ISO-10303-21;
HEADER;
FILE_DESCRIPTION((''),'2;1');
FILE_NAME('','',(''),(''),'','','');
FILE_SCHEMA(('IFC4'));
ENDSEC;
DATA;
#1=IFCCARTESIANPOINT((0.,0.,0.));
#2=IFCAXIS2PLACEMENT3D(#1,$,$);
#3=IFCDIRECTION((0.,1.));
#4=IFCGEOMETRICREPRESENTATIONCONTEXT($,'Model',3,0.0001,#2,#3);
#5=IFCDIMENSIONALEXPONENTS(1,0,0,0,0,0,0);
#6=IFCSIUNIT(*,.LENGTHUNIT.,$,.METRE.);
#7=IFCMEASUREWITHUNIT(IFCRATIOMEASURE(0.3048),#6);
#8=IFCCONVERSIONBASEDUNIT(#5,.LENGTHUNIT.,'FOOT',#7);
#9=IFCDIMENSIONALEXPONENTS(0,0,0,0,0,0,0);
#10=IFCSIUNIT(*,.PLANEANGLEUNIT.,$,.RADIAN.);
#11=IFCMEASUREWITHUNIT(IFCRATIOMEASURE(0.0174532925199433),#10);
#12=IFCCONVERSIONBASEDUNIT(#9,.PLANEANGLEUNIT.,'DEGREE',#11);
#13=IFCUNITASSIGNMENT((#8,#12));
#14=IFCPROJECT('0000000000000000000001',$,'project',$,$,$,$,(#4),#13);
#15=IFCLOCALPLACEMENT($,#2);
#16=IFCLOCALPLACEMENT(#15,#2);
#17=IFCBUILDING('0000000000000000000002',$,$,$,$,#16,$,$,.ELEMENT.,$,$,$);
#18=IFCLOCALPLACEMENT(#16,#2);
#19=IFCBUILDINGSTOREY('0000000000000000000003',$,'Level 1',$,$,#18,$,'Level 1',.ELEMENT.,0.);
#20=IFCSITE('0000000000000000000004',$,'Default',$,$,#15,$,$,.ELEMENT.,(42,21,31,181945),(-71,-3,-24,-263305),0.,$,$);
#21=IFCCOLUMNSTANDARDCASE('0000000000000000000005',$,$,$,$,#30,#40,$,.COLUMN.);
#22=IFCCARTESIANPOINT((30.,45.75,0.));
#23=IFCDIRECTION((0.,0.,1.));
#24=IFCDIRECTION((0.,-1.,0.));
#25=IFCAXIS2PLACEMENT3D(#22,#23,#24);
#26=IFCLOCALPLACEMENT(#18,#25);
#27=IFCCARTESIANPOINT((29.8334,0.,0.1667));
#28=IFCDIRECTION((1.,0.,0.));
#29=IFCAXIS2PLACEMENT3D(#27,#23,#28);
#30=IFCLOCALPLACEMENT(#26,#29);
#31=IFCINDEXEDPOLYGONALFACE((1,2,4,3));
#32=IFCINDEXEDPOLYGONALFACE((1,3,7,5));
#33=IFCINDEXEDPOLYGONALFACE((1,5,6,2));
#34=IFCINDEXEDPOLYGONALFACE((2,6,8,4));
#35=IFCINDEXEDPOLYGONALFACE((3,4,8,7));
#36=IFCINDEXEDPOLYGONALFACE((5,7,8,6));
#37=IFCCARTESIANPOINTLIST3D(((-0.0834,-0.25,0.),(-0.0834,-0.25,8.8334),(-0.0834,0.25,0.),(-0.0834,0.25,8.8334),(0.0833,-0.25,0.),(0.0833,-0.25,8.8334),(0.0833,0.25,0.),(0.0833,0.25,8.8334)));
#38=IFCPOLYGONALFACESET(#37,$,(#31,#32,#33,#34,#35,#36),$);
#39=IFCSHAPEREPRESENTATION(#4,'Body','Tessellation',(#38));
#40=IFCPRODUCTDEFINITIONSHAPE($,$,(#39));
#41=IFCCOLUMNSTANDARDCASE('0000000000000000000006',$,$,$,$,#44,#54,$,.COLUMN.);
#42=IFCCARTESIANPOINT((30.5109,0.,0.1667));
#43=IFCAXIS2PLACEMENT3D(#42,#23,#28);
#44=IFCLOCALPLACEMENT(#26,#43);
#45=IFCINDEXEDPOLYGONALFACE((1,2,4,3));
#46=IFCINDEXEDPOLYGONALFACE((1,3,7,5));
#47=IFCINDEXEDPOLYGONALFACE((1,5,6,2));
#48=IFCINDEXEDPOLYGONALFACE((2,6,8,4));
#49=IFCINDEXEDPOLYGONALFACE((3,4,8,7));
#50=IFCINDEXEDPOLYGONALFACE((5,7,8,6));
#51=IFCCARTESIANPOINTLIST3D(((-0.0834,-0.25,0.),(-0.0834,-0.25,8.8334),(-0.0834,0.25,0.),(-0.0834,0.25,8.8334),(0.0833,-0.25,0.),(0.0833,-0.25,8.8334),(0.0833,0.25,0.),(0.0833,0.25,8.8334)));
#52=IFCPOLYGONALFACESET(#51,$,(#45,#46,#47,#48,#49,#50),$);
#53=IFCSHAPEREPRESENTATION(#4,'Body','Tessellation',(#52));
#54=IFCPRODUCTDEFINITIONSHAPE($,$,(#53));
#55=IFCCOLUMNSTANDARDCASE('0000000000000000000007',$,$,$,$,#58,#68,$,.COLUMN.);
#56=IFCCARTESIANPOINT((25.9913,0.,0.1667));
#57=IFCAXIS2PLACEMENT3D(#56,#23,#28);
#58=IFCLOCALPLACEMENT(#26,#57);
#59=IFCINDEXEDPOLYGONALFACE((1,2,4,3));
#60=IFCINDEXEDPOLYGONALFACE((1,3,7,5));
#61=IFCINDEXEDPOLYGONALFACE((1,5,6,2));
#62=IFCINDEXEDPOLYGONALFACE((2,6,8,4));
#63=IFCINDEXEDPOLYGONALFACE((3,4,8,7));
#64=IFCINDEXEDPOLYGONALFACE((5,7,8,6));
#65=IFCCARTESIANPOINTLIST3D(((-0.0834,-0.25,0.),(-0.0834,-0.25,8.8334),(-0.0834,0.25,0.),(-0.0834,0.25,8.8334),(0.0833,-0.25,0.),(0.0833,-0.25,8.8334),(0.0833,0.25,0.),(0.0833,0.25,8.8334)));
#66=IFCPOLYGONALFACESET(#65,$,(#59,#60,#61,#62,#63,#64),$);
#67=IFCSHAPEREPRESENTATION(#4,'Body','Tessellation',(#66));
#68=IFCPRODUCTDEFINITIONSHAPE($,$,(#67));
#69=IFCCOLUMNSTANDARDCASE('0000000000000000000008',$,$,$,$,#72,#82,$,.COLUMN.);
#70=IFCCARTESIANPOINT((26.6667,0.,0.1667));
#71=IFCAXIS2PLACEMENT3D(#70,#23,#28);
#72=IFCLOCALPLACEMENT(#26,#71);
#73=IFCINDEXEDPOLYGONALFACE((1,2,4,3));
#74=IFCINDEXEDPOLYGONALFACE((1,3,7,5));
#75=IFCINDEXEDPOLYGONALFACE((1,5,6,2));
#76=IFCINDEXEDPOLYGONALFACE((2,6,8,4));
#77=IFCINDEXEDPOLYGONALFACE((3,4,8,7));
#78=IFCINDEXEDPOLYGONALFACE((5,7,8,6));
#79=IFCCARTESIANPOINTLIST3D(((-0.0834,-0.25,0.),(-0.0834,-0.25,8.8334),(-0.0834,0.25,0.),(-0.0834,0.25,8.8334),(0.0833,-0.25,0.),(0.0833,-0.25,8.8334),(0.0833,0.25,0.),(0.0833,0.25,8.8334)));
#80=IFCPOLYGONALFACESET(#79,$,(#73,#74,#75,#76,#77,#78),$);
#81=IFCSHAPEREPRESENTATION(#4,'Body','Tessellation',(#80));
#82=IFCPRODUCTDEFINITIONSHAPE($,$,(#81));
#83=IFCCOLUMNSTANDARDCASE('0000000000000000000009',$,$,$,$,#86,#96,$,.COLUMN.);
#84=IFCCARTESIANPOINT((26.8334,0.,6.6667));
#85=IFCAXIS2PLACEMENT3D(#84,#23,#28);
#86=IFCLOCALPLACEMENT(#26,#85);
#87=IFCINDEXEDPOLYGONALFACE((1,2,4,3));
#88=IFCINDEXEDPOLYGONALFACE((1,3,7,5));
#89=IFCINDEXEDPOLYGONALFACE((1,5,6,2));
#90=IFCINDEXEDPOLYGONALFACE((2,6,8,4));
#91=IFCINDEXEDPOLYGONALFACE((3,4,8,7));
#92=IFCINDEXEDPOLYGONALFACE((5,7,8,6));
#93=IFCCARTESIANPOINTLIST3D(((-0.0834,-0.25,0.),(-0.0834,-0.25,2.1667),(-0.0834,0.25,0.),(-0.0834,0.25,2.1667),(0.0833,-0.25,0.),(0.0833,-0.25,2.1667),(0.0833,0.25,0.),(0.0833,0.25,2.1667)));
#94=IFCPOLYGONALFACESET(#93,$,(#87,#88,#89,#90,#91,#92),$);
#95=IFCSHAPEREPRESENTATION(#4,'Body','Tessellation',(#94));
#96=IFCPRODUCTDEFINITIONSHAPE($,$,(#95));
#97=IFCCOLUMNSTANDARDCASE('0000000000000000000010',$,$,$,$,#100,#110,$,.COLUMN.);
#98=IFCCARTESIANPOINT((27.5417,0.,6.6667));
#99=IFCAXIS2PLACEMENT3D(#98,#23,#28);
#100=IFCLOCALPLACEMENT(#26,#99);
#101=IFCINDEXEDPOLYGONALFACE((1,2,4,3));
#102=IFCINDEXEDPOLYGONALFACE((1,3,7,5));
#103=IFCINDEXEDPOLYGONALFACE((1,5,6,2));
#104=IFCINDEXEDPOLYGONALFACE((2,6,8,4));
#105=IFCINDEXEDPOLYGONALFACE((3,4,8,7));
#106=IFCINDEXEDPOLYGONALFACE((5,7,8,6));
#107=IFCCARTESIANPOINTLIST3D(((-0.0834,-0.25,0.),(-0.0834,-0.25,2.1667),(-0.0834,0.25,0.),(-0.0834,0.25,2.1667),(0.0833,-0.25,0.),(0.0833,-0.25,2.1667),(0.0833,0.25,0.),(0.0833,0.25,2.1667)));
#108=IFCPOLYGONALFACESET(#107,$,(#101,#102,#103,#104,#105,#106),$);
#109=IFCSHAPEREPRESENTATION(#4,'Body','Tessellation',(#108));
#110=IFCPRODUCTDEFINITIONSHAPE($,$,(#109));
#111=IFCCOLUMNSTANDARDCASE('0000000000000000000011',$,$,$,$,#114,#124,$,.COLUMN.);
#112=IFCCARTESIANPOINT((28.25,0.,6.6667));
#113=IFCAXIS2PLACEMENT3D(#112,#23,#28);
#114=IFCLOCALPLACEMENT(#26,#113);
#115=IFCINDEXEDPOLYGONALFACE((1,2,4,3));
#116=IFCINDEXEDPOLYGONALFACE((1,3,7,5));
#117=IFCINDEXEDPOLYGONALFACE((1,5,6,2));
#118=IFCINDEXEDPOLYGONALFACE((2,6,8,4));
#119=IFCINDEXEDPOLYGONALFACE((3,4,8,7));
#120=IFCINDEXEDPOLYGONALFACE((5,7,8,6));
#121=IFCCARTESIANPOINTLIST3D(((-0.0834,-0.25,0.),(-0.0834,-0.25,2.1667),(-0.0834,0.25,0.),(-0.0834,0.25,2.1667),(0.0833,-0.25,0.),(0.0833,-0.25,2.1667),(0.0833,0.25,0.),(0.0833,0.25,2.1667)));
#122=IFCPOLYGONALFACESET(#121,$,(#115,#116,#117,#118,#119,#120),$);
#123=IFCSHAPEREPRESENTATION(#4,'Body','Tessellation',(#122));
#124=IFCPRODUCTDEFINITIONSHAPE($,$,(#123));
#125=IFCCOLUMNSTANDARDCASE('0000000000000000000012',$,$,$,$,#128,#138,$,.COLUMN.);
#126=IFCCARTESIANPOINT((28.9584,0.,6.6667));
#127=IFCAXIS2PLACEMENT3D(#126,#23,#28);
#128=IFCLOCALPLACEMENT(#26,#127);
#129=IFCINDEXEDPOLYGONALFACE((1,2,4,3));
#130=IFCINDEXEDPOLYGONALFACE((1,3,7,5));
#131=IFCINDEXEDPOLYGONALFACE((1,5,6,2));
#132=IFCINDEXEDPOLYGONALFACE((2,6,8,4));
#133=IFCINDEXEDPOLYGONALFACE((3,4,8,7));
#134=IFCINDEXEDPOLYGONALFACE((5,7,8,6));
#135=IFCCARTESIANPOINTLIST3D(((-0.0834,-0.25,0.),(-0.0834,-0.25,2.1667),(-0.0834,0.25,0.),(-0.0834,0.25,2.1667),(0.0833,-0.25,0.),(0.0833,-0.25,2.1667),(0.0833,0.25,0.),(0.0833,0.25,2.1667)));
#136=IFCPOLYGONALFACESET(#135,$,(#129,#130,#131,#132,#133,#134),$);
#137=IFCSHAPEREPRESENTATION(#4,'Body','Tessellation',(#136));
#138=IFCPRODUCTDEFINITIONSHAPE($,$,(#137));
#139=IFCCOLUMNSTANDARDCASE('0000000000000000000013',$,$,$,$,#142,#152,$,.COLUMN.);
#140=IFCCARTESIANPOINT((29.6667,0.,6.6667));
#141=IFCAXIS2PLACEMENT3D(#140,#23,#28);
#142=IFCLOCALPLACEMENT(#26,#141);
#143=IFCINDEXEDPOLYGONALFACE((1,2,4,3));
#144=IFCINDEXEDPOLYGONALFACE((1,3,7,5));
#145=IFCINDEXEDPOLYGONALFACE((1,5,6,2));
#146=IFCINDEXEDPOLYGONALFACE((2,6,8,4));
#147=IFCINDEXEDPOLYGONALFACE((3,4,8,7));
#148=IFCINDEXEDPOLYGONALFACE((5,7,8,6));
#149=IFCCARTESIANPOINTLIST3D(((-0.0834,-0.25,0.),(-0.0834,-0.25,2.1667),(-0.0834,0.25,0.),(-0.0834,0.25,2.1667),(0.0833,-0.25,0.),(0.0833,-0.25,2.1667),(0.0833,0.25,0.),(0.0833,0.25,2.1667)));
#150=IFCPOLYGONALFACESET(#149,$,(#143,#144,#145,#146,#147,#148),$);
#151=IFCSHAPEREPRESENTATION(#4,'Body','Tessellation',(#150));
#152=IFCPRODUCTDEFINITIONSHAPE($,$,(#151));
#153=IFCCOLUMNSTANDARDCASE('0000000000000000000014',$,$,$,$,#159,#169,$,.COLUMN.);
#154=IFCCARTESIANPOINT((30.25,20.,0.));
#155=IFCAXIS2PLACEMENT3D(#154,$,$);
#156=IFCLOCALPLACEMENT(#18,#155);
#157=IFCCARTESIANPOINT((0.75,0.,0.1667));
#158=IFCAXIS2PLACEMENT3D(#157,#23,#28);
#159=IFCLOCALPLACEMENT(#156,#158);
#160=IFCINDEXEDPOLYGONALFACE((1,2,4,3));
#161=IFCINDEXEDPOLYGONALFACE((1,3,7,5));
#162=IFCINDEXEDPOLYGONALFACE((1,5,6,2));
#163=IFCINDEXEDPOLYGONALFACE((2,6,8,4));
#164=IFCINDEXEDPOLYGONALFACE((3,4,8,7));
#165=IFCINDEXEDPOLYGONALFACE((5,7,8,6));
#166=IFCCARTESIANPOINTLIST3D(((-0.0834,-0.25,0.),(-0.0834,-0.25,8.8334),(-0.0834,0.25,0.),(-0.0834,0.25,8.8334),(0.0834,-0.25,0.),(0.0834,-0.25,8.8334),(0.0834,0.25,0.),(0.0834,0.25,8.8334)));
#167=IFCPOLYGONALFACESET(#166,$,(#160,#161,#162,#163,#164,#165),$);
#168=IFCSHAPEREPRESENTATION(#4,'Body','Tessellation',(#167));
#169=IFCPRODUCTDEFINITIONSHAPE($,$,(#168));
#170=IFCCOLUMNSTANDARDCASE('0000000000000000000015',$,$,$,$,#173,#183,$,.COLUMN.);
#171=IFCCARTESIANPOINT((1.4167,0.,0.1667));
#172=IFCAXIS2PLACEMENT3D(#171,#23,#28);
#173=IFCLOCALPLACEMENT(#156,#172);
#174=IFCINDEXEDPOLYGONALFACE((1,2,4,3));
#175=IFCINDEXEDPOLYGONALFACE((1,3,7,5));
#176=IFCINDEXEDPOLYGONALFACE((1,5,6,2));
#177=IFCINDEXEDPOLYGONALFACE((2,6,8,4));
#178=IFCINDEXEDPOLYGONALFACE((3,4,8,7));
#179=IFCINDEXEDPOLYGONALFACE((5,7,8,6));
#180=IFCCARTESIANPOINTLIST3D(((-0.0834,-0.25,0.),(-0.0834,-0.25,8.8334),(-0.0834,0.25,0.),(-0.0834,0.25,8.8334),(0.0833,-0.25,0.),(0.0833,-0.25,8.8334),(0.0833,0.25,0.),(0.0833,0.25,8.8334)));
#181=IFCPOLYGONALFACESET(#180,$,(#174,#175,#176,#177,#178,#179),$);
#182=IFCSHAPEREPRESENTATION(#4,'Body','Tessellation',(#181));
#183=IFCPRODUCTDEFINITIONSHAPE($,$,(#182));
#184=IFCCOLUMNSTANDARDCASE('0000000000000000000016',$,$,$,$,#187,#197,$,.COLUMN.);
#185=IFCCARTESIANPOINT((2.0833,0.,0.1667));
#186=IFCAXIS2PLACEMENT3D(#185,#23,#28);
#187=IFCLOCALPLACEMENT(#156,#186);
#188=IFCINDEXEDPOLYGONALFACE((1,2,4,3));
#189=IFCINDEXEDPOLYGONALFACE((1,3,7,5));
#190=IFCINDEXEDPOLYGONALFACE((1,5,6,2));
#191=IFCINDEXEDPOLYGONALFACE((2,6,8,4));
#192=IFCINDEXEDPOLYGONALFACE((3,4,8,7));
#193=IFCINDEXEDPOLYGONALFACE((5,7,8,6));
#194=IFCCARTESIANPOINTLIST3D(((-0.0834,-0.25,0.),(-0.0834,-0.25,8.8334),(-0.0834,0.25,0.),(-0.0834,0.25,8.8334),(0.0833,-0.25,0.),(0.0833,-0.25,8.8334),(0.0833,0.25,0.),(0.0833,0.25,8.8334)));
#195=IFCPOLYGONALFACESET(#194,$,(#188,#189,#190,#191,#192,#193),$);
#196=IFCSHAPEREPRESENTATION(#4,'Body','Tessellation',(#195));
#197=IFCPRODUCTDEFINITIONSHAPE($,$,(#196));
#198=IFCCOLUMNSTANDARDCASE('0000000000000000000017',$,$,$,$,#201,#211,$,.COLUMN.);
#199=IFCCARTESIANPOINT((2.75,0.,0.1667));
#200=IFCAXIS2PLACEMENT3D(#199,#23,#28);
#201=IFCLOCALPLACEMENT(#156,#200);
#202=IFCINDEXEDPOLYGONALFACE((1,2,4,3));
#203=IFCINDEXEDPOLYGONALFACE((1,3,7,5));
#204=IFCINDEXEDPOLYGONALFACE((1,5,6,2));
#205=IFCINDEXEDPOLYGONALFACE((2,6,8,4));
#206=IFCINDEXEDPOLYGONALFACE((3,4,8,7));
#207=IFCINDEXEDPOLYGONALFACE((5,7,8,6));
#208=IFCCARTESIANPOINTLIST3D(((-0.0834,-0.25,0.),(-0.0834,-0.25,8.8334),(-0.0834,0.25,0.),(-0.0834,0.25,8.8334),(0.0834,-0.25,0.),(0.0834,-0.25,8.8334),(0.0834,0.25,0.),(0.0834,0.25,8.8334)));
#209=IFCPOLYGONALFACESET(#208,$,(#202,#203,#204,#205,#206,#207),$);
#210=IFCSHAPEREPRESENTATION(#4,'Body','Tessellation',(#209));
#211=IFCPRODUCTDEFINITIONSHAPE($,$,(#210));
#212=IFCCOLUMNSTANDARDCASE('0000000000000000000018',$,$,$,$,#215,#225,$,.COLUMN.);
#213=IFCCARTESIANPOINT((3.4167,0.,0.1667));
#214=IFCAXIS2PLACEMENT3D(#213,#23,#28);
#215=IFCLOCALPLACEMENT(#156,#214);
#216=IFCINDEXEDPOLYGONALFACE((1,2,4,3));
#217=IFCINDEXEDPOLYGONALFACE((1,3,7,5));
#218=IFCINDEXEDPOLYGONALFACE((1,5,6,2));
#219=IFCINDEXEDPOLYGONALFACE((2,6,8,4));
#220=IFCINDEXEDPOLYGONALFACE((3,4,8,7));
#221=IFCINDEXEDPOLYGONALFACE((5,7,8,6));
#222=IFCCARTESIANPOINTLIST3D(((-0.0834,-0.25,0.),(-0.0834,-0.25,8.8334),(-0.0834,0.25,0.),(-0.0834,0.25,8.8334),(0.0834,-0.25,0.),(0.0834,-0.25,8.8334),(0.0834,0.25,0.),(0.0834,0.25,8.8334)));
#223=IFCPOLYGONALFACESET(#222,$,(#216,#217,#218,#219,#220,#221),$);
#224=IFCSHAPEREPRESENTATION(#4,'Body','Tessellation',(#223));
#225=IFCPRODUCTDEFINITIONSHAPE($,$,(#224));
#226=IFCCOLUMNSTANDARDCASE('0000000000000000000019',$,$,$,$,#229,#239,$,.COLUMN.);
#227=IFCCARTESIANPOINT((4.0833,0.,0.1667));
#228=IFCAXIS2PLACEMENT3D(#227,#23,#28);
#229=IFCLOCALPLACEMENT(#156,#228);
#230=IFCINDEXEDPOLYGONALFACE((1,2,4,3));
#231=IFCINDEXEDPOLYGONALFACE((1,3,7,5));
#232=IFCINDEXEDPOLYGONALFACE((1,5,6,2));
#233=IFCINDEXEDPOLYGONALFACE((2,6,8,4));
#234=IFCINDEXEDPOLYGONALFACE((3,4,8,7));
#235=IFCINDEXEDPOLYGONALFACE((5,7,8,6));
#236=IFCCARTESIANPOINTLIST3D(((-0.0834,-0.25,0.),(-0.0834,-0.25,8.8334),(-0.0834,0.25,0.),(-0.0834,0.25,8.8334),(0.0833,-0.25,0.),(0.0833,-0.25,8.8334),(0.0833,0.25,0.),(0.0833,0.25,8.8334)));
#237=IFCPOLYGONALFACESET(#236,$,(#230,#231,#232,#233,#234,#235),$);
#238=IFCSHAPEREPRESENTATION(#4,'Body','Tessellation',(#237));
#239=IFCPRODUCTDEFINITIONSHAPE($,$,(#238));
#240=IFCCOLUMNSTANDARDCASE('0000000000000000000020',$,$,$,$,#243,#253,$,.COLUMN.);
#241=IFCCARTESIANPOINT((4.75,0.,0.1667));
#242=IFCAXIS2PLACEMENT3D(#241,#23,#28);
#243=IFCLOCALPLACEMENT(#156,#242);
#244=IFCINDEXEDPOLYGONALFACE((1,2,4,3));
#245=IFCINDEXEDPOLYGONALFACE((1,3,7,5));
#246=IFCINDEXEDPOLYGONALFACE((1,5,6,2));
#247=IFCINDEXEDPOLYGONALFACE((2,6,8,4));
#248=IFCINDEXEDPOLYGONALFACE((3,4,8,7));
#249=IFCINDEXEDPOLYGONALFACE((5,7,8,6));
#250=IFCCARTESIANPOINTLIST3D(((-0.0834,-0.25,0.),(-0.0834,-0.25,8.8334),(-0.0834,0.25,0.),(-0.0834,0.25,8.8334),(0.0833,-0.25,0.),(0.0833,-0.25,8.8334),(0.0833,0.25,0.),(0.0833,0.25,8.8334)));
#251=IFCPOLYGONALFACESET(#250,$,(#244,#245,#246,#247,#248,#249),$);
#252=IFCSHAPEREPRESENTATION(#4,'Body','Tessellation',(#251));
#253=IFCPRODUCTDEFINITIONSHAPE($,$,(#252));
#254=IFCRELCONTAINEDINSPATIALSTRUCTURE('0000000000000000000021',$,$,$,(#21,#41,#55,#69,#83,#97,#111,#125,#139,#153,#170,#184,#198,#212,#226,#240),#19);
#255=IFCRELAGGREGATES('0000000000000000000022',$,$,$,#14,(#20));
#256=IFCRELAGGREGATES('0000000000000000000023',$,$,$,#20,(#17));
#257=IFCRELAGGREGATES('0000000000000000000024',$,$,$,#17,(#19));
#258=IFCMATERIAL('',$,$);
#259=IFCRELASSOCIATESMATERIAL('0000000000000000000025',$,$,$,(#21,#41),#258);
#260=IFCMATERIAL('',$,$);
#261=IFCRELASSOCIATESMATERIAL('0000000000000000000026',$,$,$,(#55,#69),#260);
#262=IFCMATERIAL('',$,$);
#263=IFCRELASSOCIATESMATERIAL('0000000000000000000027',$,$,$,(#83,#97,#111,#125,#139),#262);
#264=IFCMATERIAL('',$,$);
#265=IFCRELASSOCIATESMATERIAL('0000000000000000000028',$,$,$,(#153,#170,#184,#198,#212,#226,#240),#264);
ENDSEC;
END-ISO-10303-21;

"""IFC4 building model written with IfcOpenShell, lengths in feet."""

from ifc_helpers import new_model, entity, si_unit, converted_unit, direction, frame, origin, place, context, project, spatial, rectangle, extrude, material, element, save


model = new_model("IFC4")

# Units and contexts
model_context = context("Model", 3, precision=0.0001, world=origin(), true_north=direction((0.0, 1.0)))
ifc_project = project(units=[converted_unit("LENGTHUNIT", "FOOT", entity("IfcRatioMeasure", 0.3048), si_unit("LENGTHUNIT", "METRE"), dimensions=[1, 0, 0, 0, 0, 0, 0]), converted_unit("PLANEANGLEUNIT", "DEGREE", entity("IfcRatioMeasure", 0.0174532925199433), si_unit("PLANEANGLEUNIT", "RADIAN"), dimensions=[0, 0, 0, 0, 0, 0, 0])], contexts=[model_context])

# Site, building, storey
site_placement = place(None, origin())
site = spatial("IfcSite", under=ifc_project, at=site_placement, Name="Default", CompositionType="ELEMENT", RefLatitude=(42, 21, 31, 181945), RefLongitude=(-71, -3, -24, -263305), RefElevation=0.0)
building_placement = place(site_placement, origin())
building = spatial("IfcBuilding", under=site, at=building_placement, CompositionType="ELEMENT")
storey_placement = place(building_placement, origin())
storey = spatial("IfcBuildingStorey", under=building, at=storey_placement, Name="Level 1", LongName="Level 1", CompositionType="ELEMENT", Elevation=0.0)

# Columns
ifc_material_1 = material(Name="")
placement_1 = place(storey_placement, frame((30.0, 45.75, 0.0), z_axis=(0.0, 0.0, 1.0), x_axis=(0.0, -1.0, 0.0)))
for number, where, z_axis, x_axis in (
    (1, (29.8334, 0.0, 0.1667), (0.0, 0.0, 1.0), (1.0, 0.0, 0.0)),
    (2, (30.5109, 0.0, 0.1667), (0.0, 0.0, 1.0), (1.0, 0.0, 0.0)),
):
    element("IfcColumnStandardCase", number, at=place(placement_1, frame(where, z_axis=z_axis, x_axis=x_axis)), inside=storey, material=ifc_material_1, PredefinedType="COLUMN", context=model_context, shape_type="SweptSolid", body=[
        extrude(rectangle(XDim=0.1667, YDim=0.5), origin(), (0.0, 0.0, 1.0), 8.8334),
    ])
ifc_material_2 = material(Name="")
for number, where, z_axis, x_axis in (
    (3, (25.9913, 0.0, 0.1667), (0.0, 0.0, 1.0), (1.0, 0.0, 0.0)),
    (4, (26.6667, 0.0, 0.1667), (0.0, 0.0, 1.0), (1.0, 0.0, 0.0)),
):
    element("IfcColumnStandardCase", number, at=place(placement_1, frame(where, z_axis=z_axis, x_axis=x_axis)), inside=storey, material=ifc_material_2, PredefinedType="COLUMN", context=model_context, shape_type="SweptSolid", body=[
        extrude(rectangle(XDim=0.1667, YDim=0.5), origin(), (0.0, 0.0, 1.0), 8.8334),
    ])
ifc_material_3 = material(Name="")
for number, where, z_axis, x_axis in (
    (5, (26.8334, 0.0, 6.6667), (0.0, 0.0, 1.0), (1.0, 0.0, 0.0)),
    (6, (27.5417, 0.0, 6.6667), (0.0, 0.0, 1.0), (1.0, 0.0, 0.0)),
    (7, (28.25, 0.0, 6.6667), (0.0, 0.0, 1.0), (1.0, 0.0, 0.0)),
    (8, (28.9584, 0.0, 6.6667), (0.0, 0.0, 1.0), (1.0, 0.0, 0.0)),
    (9, (29.6667, 0.0, 6.6667), (0.0, 0.0, 1.0), (1.0, 0.0, 0.0)),
):
    element("IfcColumnStandardCase", number, at=place(placement_1, frame(where, z_axis=z_axis, x_axis=x_axis)), inside=storey, material=ifc_material_3, PredefinedType="COLUMN", context=model_context, shape_type="SweptSolid", body=[
        extrude(rectangle(XDim=0.1667, YDim=0.5), origin(), (0.0, 0.0, 1.0), 2.1667),
    ])
ifc_material_4 = material(Name="")
placement_2 = place(storey_placement, frame((30.25, 20.0, 0.0)))
for number, where, z_axis, x_axis in (
    (10, (0.75, 0.0, 0.1667), (0.0, 0.0, 1.0), (1.0, 0.0, 0.0)),
    (11, (1.4167, 0.0, 0.1667), (0.0, 0.0, 1.0), (1.0, 0.0, 0.0)),
    (12, (2.0833, 0.0, 0.1667), (0.0, 0.0, 1.0), (1.0, 0.0, 0.0)),
    (13, (2.75, 0.0, 0.1667), (0.0, 0.0, 1.0), (1.0, 0.0, 0.0)),
    (14, (3.4167, 0.0, 0.1667), (0.0, 0.0, 1.0), (1.0, 0.0, 0.0)),
    (15, (4.0833, 0.0, 0.1667), (0.0, 0.0, 1.0), (1.0, 0.0, 0.0)),
    (16, (4.75, 0.0, 0.1667), (0.0, 0.0, 1.0), (1.0, 0.0, 0.0)),
):
    element("IfcColumnStandardCase", number, at=place(placement_2, frame(where, z_axis=z_axis, x_axis=x_axis)), inside=storey, material=ifc_material_4, PredefinedType="COLUMN", context=model_context, shape_type="SweptSolid", body=[
        extrude(rectangle(XDim=0.1667, YDim=0.5), origin(), (0.0, 0.0, 1.0), 8.8334),
    ])

save(model, "model.ifc")
